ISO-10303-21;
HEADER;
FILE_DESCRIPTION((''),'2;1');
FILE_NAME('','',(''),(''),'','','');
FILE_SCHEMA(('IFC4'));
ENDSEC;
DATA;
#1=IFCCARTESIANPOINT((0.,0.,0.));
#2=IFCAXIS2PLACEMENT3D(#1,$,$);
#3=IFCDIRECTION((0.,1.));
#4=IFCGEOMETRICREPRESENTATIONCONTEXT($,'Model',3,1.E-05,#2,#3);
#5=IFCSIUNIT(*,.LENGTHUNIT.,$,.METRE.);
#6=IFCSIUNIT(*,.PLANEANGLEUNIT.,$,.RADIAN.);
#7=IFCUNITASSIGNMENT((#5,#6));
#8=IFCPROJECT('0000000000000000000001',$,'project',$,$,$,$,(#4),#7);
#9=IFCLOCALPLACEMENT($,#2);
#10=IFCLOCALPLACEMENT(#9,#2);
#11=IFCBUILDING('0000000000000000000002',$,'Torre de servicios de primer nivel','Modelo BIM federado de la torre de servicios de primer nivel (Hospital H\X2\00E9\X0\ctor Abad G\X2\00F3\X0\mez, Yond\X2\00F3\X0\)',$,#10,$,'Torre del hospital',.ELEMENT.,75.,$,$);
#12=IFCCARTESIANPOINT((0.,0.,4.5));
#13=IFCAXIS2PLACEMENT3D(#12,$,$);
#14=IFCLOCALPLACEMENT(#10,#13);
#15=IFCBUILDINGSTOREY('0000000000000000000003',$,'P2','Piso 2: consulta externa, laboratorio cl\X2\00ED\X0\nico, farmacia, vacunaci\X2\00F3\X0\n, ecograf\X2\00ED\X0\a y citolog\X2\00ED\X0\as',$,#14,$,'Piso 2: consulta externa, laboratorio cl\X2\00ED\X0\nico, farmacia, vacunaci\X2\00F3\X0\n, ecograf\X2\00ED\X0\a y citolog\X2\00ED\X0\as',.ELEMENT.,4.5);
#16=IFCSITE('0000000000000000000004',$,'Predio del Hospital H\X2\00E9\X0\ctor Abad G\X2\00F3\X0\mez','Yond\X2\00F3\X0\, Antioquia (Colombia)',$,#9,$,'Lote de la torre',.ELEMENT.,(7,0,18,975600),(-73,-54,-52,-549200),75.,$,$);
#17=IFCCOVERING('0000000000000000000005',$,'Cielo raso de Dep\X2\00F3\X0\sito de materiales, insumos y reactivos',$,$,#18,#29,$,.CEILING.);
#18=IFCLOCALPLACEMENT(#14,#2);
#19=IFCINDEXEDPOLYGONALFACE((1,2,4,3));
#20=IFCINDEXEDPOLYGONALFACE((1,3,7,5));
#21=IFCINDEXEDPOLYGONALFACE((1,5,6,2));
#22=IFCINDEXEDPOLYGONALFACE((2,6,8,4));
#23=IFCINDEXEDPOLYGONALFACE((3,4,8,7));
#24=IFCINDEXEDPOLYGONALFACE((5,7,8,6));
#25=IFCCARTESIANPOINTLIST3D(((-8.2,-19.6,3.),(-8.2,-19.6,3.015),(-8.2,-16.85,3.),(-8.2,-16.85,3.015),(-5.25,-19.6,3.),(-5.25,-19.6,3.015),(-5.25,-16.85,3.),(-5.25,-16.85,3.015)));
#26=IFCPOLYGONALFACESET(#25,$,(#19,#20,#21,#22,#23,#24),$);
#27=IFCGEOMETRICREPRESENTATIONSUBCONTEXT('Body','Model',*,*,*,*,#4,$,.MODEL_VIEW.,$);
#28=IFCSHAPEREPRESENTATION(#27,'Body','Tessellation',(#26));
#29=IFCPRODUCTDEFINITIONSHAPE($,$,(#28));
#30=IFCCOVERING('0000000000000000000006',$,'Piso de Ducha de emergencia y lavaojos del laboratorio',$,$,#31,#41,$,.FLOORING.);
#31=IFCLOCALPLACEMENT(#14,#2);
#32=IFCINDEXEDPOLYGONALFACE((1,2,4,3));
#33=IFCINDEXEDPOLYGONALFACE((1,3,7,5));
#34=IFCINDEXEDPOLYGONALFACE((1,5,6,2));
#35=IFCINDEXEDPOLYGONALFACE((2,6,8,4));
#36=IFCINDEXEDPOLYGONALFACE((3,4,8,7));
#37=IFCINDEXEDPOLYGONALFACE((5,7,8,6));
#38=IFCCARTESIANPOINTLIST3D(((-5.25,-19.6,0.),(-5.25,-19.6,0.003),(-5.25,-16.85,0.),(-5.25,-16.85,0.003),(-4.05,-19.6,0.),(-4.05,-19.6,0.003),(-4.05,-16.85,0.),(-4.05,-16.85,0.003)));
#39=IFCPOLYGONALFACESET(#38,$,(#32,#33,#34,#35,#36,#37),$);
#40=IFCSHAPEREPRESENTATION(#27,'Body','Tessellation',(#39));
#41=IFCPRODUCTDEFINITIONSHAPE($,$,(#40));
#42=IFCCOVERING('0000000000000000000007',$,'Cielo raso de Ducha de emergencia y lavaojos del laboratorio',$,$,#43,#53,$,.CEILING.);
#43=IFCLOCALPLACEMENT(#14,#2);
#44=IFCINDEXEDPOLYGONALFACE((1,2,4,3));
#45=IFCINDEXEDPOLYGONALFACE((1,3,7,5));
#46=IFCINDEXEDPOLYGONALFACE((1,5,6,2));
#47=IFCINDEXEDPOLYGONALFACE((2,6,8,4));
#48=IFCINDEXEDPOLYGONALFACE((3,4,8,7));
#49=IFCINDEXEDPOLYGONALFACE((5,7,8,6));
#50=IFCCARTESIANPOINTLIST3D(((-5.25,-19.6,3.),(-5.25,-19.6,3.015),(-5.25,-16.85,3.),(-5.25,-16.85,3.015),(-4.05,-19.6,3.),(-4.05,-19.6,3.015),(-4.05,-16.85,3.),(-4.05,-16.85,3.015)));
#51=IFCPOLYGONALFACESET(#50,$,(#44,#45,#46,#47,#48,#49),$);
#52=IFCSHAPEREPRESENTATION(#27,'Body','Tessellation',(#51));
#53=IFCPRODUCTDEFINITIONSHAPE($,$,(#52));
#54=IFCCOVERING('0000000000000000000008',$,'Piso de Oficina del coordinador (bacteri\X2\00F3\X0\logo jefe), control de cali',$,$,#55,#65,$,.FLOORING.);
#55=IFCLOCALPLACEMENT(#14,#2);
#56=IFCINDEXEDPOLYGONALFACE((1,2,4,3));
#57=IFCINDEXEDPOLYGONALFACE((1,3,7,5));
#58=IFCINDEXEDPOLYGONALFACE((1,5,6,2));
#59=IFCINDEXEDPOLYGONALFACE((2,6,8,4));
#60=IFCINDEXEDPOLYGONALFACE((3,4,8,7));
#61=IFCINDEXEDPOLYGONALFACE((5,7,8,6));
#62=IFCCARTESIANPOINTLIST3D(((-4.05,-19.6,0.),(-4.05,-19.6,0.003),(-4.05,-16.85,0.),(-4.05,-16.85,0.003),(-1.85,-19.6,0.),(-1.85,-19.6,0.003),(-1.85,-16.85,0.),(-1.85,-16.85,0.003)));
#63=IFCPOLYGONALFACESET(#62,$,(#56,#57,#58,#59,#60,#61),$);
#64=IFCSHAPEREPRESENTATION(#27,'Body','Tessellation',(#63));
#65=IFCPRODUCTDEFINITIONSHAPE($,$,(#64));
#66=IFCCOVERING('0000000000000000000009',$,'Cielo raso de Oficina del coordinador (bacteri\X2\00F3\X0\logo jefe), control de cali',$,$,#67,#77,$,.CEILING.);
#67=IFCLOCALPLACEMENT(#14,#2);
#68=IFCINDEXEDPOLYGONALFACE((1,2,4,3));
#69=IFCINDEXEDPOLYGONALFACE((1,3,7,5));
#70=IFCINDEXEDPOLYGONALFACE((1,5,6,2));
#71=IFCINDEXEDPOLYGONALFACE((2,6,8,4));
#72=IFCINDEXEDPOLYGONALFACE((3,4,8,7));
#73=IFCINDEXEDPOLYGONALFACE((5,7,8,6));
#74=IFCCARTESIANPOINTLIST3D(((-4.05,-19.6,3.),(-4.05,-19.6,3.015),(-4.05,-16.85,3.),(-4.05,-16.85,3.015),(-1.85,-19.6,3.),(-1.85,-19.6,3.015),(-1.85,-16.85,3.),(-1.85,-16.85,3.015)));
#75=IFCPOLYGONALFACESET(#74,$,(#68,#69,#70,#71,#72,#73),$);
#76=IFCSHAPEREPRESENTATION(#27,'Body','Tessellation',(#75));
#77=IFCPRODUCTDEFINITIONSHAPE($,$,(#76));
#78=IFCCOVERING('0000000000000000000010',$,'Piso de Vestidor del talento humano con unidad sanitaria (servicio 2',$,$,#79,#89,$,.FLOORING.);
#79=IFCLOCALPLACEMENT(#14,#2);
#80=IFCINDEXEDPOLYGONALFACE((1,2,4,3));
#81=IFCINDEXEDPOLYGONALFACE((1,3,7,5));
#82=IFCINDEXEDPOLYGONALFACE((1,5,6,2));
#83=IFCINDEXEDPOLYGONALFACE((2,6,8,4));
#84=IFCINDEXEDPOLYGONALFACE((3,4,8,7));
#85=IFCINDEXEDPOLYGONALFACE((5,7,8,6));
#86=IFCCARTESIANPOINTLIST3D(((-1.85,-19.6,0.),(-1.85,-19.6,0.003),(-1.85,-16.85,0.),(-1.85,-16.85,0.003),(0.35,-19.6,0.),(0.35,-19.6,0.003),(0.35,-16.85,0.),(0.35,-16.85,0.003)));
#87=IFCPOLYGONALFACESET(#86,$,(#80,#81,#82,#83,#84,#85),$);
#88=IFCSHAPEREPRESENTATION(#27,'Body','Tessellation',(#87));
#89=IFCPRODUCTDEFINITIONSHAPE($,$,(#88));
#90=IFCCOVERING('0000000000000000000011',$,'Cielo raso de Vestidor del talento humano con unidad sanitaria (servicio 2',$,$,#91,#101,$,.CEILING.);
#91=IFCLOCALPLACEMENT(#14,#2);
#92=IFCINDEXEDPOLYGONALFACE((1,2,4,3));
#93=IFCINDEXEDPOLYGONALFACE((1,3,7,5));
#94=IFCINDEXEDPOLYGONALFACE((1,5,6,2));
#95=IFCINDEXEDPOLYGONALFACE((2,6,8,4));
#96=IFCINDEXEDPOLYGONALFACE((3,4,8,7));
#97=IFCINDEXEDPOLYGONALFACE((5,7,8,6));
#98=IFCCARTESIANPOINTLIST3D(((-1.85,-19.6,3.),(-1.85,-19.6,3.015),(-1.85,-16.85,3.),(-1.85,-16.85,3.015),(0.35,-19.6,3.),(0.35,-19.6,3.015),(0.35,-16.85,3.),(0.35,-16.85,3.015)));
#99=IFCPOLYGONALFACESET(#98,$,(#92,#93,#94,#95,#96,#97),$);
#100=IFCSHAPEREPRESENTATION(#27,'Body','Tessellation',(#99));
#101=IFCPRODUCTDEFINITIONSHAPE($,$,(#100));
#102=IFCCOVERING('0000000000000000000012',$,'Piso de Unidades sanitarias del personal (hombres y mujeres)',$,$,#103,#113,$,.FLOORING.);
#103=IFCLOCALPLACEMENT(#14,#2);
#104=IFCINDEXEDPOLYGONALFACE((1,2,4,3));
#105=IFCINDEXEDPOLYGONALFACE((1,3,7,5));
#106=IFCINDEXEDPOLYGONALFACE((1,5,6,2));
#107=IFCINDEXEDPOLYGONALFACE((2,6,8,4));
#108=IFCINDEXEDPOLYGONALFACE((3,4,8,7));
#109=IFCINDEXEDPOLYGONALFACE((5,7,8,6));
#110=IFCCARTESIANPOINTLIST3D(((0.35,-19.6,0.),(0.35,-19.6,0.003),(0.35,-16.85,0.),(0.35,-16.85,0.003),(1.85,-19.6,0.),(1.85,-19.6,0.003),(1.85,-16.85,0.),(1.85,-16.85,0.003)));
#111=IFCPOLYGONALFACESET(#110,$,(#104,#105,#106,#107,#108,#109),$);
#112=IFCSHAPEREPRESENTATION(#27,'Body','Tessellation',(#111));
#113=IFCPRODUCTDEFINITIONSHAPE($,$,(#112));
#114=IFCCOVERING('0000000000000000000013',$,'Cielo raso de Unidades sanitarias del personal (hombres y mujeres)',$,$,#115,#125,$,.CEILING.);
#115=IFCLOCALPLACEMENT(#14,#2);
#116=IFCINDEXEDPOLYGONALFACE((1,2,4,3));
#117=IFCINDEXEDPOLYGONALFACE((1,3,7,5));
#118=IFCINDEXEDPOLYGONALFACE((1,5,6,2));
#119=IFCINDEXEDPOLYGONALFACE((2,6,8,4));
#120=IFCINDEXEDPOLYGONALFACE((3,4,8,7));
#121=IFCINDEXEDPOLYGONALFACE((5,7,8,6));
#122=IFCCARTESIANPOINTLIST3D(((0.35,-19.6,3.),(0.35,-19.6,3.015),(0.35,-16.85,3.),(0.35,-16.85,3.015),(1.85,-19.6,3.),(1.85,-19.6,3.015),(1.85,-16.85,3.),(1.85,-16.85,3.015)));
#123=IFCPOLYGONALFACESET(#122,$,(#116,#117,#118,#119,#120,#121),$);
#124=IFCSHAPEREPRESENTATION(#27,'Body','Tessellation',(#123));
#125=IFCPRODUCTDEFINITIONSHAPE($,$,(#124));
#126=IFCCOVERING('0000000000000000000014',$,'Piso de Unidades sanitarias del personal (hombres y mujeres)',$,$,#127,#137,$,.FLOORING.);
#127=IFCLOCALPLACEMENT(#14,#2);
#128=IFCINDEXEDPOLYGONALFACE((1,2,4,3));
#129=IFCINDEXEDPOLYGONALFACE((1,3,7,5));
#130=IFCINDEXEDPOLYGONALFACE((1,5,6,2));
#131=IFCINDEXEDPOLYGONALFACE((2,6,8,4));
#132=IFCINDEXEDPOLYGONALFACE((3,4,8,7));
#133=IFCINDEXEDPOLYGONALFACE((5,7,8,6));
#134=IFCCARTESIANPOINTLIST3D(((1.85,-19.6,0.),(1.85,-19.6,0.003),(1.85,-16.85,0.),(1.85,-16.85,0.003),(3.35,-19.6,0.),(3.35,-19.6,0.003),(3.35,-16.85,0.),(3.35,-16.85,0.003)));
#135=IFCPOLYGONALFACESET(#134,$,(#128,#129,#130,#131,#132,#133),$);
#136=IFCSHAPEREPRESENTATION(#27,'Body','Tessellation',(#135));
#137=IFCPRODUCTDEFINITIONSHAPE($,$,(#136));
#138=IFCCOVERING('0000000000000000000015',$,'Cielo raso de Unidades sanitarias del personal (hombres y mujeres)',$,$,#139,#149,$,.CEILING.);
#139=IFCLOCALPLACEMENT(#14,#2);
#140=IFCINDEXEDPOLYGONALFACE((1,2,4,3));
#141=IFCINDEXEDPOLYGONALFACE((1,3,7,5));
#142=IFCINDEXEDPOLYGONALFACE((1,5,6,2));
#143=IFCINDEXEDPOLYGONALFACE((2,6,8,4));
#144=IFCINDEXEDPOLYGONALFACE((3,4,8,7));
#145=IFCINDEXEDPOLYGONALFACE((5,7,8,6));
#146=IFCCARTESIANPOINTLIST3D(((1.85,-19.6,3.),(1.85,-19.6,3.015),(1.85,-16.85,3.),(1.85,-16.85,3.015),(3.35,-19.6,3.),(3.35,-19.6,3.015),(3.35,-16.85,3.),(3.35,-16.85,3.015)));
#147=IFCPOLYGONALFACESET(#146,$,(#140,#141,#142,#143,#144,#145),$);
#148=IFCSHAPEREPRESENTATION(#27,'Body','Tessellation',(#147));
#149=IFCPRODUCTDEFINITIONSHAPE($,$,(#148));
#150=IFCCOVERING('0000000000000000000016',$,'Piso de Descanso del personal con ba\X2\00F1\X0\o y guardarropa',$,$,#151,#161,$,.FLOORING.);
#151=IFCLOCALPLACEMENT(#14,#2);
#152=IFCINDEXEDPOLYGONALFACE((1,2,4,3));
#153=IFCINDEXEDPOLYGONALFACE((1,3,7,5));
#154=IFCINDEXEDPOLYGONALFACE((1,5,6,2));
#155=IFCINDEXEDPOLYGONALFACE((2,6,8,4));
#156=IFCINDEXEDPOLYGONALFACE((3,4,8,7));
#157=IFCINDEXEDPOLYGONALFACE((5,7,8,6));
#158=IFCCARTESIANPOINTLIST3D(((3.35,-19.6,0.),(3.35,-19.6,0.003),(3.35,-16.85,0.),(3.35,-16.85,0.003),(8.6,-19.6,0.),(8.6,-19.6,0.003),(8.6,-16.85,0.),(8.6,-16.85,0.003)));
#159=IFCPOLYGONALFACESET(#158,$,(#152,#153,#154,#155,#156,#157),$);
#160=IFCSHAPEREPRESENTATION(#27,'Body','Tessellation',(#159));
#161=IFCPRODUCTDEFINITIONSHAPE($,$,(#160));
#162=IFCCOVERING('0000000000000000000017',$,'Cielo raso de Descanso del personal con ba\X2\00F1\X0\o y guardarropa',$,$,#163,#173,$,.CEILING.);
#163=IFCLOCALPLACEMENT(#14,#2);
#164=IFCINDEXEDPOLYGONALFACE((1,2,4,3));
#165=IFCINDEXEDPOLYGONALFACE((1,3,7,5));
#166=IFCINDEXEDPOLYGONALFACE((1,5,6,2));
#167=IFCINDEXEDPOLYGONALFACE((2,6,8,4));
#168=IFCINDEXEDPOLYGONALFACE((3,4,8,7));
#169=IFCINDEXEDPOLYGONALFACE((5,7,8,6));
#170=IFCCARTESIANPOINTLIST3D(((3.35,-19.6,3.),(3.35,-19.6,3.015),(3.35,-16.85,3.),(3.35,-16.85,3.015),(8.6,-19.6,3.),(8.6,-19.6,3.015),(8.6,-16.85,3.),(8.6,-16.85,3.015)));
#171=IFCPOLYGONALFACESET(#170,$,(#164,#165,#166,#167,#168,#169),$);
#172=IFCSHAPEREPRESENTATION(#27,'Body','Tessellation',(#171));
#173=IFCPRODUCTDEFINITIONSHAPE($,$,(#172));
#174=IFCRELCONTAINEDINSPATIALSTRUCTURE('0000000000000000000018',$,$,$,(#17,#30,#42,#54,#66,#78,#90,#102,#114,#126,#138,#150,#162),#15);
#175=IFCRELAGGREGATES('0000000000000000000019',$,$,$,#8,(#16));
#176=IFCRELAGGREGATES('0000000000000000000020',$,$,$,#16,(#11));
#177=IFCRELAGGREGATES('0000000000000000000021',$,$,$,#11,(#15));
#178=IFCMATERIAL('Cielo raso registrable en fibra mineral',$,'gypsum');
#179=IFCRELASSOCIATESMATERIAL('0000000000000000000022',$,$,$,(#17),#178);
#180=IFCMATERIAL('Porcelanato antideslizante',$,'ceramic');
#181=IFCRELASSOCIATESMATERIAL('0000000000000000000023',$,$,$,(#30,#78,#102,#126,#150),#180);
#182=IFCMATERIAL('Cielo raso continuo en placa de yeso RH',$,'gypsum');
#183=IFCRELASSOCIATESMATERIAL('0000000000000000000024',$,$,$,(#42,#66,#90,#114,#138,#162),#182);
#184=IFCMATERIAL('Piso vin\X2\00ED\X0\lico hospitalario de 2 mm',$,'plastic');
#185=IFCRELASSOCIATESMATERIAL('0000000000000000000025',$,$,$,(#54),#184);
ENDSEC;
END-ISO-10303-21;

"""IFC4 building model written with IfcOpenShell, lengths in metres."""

from ifc_helpers import new_model, si_unit, direction, frame, origin, place, context, subcontext, project, spatial, indexed_curve, outline, extrude, material, element, save


model = new_model("IFC4")

# Units and contexts
model_context = context("Model", 3, precision=1e-05, world=origin(), true_north=direction((0.0, 1.0)))
body_context = subcontext(model_context, "Body", "Model", "MODEL_VIEW")
ifc_project = project(units=[si_unit("LENGTHUNIT", "METRE"), si_unit("PLANEANGLEUNIT", "RADIAN")], contexts=[model_context])

# Site, building, storey
site_placement = place(None, origin())
site = spatial("IfcSite", under=ifc_project, at=site_placement, Name="Predio del Hospital Héctor Abad Gómez", Description="Yondó, Antioquia (Colombia)", LongName="Lote de la torre", CompositionType="ELEMENT", RefLatitude=(7, 0, 18, 975600), RefLongitude=(-73, -54, -52, -549200), RefElevation=75.0)
building_placement = place(site_placement, origin())
building = spatial("IfcBuilding", under=site, at=building_placement, Name="Torre de servicios de primer nivel", Description="Modelo BIM federado de la torre de servicios de primer nivel (Hospital Héctor Abad Gómez, Yondó)", LongName="Torre del hospital", CompositionType="ELEMENT", ElevationOfRefHeight=75.0)
placement = place(building_placement, frame((0.0, 0.0, 4.5)))
storey = spatial("IfcBuildingStorey", under=building, at=placement, Name="P2", Description="Piso 2: consulta externa, laboratorio clínico, farmacia, vacunación, ecografía y citologías", LongName="Piso 2: consulta externa, laboratorio clínico, farmacia, vacunación, ecografía y citologías", CompositionType="ELEMENT", Elevation=4.5)

# Coverings
ifc_material_1 = material(Name="Cielo raso registrable en fibra mineral", Category="gypsum")
ifc_material_2 = material(Name="Piso vinílico hospitalario de 2 mm", Category="plastic")
ifc_material_3 = material(Name="Cielo raso continuo en placa de yeso RH", Category="gypsum")
ifc_material_4 = material(Name="Porcelanato antideslizante", Category="ceramic")
element("IfcCovering", 1, at=placement, inside=storey, material=ifc_material_1, Name="Cielo raso de Depósito de materiales, insumos y reactivos", PredefinedType="CEILING", context=body_context, shape_type="SweptSolid", body=[
    extrude(outline(indexed_curve([(-8.2, -19.6), (-5.25, -19.6), (-5.25, -16.85), (-8.2, -16.85), (-8.2, -19.6)], self_intersect=False)), frame((0.0, 0.0, 3.0)), (0.0, 0.0, 1.0), 0.015),
])
element("IfcCovering", 2, at=placement, inside=storey, material=ifc_material_4, Name="Piso de Ducha de emergencia y lavaojos del laboratorio", PredefinedType="FLOORING", context=body_context, shape_type="SweptSolid", body=[
    extrude(outline(indexed_curve([(-5.25, -19.6), (-4.05, -19.6), (-4.05, -16.85), (-5.25, -16.85), (-5.25, -19.6)], self_intersect=False)), origin(), (0.0, 0.0, 1.0), 0.003),
])
element("IfcCovering", 3, at=placement, inside=storey, material=ifc_material_3, Name="Cielo raso de Ducha de emergencia y lavaojos del laboratorio", PredefinedType="CEILING", context=body_context, shape_type="SweptSolid", body=[
    extrude(outline(indexed_curve([(-5.25, -19.6), (-4.05, -19.6), (-4.05, -16.85), (-5.25, -16.85), (-5.25, -19.6)], self_intersect=False)), frame((0.0, 0.0, 3.0)), (0.0, 0.0, 1.0), 0.015),
])
element("IfcCovering", 4, at=placement, inside=storey, material=ifc_material_2, Name="Piso de Oficina del coordinador (bacteriólogo jefe), control de cali", PredefinedType="FLOORING", context=body_context, shape_type="SweptSolid", body=[
    extrude(outline(indexed_curve([(-4.05, -19.6), (-1.85, -19.6), (-1.85, -16.85), (-4.05, -16.85), (-4.05, -19.6)], self_intersect=False)), origin(), (0.0, 0.0, 1.0), 0.003),
])
element("IfcCovering", 5, at=placement, inside=storey, material=ifc_material_3, Name="Cielo raso de Oficina del coordinador (bacteriólogo jefe), control de cali", PredefinedType="CEILING", context=body_context, shape_type="SweptSolid", body=[
    extrude(outline(indexed_curve([(-4.05, -19.6), (-1.85, -19.6), (-1.85, -16.85), (-4.05, -16.85), (-4.05, -19.6)], self_intersect=False)), frame((0.0, 0.0, 3.0)), (0.0, 0.0, 1.0), 0.015),
])
element("IfcCovering", 6, at=placement, inside=storey, material=ifc_material_4, Name="Piso de Vestidor del talento humano con unidad sanitaria (servicio 2", PredefinedType="FLOORING", context=body_context, shape_type="SweptSolid", body=[
    extrude(outline(indexed_curve([(-1.85, -19.6), (0.35, -19.6), (0.35, -16.85), (-1.85, -16.85), (-1.85, -19.6)], self_intersect=False)), origin(), (0.0, 0.0, 1.0), 0.003),
])
element("IfcCovering", 7, at=placement, inside=storey, material=ifc_material_3, Name="Cielo raso de Vestidor del talento humano con unidad sanitaria (servicio 2", PredefinedType="CEILING", context=body_context, shape_type="SweptSolid", body=[
    extrude(outline(indexed_curve([(-1.85, -19.6), (0.35, -19.6), (0.35, -16.85), (-1.85, -16.85), (-1.85, -19.6)], self_intersect=False)), frame((0.0, 0.0, 3.0)), (0.0, 0.0, 1.0), 0.015),
])
element("IfcCovering", 8, at=placement, inside=storey, material=ifc_material_4, Name="Piso de Unidades sanitarias del personal (hombres y mujeres)", PredefinedType="FLOORING", context=body_context, shape_type="SweptSolid", body=[
    extrude(outline(indexed_curve([(0.35, -19.6), (1.85, -19.6), (1.85, -16.85), (0.35, -16.85), (0.35, -19.6)], self_intersect=False)), origin(), (0.0, 0.0, 1.0), 0.003),
])
element("IfcCovering", 9, at=placement, inside=storey, material=ifc_material_3, Name="Cielo raso de Unidades sanitarias del personal (hombres y mujeres)", PredefinedType="CEILING", context=body_context, shape_type="SweptSolid", body=[
    extrude(outline(indexed_curve([(0.35, -19.6), (1.85, -19.6), (1.85, -16.85), (0.35, -16.85), (0.35, -19.6)], self_intersect=False)), frame((0.0, 0.0, 3.0)), (0.0, 0.0, 1.0), 0.015),
])
element("IfcCovering", 10, at=placement, inside=storey, material=ifc_material_4, Name="Piso de Unidades sanitarias del personal (hombres y mujeres)", PredefinedType="FLOORING", context=body_context, shape_type="SweptSolid", body=[
    extrude(outline(indexed_curve([(1.85, -19.6), (3.35, -19.6), (3.35, -16.85), (1.85, -16.85), (1.85, -19.6)], self_intersect=False)), origin(), (0.0, 0.0, 1.0), 0.003),
])
element("IfcCovering", 11, at=placement, inside=storey, material=ifc_material_3, Name="Cielo raso de Unidades sanitarias del personal (hombres y mujeres)", PredefinedType="CEILING", context=body_context, shape_type="SweptSolid", body=[
    extrude(outline(indexed_curve([(1.85, -19.6), (3.35, -19.6), (3.35, -16.85), (1.85, -16.85), (1.85, -19.6)], self_intersect=False)), frame((0.0, 0.0, 3.0)), (0.0, 0.0, 1.0), 0.015),
])
element("IfcCovering", 12, at=placement, inside=storey, material=ifc_material_4, Name="Piso de Descanso del personal con baño y guardarropa", PredefinedType="FLOORING", context=body_context, shape_type="SweptSolid", body=[
    extrude(outline(indexed_curve([(3.35, -19.6), (8.6, -19.6), (8.6, -16.85), (3.35, -16.85), (3.35, -19.6)], self_intersect=False)), origin(), (0.0, 0.0, 1.0), 0.003),
])
element("IfcCovering", 13, at=placement, inside=storey, material=ifc_material_3, Name="Cielo raso de Descanso del personal con baño y guardarropa", PredefinedType="CEILING", context=body_context, shape_type="SweptSolid", body=[
    extrude(outline(indexed_curve([(3.35, -19.6), (8.6, -19.6), (8.6, -16.85), (3.35, -16.85), (3.35, -19.6)], self_intersect=False)), frame((0.0, 0.0, 3.0)), (0.0, 0.0, 1.0), 0.015),
])

save(model, "model.ifc")
